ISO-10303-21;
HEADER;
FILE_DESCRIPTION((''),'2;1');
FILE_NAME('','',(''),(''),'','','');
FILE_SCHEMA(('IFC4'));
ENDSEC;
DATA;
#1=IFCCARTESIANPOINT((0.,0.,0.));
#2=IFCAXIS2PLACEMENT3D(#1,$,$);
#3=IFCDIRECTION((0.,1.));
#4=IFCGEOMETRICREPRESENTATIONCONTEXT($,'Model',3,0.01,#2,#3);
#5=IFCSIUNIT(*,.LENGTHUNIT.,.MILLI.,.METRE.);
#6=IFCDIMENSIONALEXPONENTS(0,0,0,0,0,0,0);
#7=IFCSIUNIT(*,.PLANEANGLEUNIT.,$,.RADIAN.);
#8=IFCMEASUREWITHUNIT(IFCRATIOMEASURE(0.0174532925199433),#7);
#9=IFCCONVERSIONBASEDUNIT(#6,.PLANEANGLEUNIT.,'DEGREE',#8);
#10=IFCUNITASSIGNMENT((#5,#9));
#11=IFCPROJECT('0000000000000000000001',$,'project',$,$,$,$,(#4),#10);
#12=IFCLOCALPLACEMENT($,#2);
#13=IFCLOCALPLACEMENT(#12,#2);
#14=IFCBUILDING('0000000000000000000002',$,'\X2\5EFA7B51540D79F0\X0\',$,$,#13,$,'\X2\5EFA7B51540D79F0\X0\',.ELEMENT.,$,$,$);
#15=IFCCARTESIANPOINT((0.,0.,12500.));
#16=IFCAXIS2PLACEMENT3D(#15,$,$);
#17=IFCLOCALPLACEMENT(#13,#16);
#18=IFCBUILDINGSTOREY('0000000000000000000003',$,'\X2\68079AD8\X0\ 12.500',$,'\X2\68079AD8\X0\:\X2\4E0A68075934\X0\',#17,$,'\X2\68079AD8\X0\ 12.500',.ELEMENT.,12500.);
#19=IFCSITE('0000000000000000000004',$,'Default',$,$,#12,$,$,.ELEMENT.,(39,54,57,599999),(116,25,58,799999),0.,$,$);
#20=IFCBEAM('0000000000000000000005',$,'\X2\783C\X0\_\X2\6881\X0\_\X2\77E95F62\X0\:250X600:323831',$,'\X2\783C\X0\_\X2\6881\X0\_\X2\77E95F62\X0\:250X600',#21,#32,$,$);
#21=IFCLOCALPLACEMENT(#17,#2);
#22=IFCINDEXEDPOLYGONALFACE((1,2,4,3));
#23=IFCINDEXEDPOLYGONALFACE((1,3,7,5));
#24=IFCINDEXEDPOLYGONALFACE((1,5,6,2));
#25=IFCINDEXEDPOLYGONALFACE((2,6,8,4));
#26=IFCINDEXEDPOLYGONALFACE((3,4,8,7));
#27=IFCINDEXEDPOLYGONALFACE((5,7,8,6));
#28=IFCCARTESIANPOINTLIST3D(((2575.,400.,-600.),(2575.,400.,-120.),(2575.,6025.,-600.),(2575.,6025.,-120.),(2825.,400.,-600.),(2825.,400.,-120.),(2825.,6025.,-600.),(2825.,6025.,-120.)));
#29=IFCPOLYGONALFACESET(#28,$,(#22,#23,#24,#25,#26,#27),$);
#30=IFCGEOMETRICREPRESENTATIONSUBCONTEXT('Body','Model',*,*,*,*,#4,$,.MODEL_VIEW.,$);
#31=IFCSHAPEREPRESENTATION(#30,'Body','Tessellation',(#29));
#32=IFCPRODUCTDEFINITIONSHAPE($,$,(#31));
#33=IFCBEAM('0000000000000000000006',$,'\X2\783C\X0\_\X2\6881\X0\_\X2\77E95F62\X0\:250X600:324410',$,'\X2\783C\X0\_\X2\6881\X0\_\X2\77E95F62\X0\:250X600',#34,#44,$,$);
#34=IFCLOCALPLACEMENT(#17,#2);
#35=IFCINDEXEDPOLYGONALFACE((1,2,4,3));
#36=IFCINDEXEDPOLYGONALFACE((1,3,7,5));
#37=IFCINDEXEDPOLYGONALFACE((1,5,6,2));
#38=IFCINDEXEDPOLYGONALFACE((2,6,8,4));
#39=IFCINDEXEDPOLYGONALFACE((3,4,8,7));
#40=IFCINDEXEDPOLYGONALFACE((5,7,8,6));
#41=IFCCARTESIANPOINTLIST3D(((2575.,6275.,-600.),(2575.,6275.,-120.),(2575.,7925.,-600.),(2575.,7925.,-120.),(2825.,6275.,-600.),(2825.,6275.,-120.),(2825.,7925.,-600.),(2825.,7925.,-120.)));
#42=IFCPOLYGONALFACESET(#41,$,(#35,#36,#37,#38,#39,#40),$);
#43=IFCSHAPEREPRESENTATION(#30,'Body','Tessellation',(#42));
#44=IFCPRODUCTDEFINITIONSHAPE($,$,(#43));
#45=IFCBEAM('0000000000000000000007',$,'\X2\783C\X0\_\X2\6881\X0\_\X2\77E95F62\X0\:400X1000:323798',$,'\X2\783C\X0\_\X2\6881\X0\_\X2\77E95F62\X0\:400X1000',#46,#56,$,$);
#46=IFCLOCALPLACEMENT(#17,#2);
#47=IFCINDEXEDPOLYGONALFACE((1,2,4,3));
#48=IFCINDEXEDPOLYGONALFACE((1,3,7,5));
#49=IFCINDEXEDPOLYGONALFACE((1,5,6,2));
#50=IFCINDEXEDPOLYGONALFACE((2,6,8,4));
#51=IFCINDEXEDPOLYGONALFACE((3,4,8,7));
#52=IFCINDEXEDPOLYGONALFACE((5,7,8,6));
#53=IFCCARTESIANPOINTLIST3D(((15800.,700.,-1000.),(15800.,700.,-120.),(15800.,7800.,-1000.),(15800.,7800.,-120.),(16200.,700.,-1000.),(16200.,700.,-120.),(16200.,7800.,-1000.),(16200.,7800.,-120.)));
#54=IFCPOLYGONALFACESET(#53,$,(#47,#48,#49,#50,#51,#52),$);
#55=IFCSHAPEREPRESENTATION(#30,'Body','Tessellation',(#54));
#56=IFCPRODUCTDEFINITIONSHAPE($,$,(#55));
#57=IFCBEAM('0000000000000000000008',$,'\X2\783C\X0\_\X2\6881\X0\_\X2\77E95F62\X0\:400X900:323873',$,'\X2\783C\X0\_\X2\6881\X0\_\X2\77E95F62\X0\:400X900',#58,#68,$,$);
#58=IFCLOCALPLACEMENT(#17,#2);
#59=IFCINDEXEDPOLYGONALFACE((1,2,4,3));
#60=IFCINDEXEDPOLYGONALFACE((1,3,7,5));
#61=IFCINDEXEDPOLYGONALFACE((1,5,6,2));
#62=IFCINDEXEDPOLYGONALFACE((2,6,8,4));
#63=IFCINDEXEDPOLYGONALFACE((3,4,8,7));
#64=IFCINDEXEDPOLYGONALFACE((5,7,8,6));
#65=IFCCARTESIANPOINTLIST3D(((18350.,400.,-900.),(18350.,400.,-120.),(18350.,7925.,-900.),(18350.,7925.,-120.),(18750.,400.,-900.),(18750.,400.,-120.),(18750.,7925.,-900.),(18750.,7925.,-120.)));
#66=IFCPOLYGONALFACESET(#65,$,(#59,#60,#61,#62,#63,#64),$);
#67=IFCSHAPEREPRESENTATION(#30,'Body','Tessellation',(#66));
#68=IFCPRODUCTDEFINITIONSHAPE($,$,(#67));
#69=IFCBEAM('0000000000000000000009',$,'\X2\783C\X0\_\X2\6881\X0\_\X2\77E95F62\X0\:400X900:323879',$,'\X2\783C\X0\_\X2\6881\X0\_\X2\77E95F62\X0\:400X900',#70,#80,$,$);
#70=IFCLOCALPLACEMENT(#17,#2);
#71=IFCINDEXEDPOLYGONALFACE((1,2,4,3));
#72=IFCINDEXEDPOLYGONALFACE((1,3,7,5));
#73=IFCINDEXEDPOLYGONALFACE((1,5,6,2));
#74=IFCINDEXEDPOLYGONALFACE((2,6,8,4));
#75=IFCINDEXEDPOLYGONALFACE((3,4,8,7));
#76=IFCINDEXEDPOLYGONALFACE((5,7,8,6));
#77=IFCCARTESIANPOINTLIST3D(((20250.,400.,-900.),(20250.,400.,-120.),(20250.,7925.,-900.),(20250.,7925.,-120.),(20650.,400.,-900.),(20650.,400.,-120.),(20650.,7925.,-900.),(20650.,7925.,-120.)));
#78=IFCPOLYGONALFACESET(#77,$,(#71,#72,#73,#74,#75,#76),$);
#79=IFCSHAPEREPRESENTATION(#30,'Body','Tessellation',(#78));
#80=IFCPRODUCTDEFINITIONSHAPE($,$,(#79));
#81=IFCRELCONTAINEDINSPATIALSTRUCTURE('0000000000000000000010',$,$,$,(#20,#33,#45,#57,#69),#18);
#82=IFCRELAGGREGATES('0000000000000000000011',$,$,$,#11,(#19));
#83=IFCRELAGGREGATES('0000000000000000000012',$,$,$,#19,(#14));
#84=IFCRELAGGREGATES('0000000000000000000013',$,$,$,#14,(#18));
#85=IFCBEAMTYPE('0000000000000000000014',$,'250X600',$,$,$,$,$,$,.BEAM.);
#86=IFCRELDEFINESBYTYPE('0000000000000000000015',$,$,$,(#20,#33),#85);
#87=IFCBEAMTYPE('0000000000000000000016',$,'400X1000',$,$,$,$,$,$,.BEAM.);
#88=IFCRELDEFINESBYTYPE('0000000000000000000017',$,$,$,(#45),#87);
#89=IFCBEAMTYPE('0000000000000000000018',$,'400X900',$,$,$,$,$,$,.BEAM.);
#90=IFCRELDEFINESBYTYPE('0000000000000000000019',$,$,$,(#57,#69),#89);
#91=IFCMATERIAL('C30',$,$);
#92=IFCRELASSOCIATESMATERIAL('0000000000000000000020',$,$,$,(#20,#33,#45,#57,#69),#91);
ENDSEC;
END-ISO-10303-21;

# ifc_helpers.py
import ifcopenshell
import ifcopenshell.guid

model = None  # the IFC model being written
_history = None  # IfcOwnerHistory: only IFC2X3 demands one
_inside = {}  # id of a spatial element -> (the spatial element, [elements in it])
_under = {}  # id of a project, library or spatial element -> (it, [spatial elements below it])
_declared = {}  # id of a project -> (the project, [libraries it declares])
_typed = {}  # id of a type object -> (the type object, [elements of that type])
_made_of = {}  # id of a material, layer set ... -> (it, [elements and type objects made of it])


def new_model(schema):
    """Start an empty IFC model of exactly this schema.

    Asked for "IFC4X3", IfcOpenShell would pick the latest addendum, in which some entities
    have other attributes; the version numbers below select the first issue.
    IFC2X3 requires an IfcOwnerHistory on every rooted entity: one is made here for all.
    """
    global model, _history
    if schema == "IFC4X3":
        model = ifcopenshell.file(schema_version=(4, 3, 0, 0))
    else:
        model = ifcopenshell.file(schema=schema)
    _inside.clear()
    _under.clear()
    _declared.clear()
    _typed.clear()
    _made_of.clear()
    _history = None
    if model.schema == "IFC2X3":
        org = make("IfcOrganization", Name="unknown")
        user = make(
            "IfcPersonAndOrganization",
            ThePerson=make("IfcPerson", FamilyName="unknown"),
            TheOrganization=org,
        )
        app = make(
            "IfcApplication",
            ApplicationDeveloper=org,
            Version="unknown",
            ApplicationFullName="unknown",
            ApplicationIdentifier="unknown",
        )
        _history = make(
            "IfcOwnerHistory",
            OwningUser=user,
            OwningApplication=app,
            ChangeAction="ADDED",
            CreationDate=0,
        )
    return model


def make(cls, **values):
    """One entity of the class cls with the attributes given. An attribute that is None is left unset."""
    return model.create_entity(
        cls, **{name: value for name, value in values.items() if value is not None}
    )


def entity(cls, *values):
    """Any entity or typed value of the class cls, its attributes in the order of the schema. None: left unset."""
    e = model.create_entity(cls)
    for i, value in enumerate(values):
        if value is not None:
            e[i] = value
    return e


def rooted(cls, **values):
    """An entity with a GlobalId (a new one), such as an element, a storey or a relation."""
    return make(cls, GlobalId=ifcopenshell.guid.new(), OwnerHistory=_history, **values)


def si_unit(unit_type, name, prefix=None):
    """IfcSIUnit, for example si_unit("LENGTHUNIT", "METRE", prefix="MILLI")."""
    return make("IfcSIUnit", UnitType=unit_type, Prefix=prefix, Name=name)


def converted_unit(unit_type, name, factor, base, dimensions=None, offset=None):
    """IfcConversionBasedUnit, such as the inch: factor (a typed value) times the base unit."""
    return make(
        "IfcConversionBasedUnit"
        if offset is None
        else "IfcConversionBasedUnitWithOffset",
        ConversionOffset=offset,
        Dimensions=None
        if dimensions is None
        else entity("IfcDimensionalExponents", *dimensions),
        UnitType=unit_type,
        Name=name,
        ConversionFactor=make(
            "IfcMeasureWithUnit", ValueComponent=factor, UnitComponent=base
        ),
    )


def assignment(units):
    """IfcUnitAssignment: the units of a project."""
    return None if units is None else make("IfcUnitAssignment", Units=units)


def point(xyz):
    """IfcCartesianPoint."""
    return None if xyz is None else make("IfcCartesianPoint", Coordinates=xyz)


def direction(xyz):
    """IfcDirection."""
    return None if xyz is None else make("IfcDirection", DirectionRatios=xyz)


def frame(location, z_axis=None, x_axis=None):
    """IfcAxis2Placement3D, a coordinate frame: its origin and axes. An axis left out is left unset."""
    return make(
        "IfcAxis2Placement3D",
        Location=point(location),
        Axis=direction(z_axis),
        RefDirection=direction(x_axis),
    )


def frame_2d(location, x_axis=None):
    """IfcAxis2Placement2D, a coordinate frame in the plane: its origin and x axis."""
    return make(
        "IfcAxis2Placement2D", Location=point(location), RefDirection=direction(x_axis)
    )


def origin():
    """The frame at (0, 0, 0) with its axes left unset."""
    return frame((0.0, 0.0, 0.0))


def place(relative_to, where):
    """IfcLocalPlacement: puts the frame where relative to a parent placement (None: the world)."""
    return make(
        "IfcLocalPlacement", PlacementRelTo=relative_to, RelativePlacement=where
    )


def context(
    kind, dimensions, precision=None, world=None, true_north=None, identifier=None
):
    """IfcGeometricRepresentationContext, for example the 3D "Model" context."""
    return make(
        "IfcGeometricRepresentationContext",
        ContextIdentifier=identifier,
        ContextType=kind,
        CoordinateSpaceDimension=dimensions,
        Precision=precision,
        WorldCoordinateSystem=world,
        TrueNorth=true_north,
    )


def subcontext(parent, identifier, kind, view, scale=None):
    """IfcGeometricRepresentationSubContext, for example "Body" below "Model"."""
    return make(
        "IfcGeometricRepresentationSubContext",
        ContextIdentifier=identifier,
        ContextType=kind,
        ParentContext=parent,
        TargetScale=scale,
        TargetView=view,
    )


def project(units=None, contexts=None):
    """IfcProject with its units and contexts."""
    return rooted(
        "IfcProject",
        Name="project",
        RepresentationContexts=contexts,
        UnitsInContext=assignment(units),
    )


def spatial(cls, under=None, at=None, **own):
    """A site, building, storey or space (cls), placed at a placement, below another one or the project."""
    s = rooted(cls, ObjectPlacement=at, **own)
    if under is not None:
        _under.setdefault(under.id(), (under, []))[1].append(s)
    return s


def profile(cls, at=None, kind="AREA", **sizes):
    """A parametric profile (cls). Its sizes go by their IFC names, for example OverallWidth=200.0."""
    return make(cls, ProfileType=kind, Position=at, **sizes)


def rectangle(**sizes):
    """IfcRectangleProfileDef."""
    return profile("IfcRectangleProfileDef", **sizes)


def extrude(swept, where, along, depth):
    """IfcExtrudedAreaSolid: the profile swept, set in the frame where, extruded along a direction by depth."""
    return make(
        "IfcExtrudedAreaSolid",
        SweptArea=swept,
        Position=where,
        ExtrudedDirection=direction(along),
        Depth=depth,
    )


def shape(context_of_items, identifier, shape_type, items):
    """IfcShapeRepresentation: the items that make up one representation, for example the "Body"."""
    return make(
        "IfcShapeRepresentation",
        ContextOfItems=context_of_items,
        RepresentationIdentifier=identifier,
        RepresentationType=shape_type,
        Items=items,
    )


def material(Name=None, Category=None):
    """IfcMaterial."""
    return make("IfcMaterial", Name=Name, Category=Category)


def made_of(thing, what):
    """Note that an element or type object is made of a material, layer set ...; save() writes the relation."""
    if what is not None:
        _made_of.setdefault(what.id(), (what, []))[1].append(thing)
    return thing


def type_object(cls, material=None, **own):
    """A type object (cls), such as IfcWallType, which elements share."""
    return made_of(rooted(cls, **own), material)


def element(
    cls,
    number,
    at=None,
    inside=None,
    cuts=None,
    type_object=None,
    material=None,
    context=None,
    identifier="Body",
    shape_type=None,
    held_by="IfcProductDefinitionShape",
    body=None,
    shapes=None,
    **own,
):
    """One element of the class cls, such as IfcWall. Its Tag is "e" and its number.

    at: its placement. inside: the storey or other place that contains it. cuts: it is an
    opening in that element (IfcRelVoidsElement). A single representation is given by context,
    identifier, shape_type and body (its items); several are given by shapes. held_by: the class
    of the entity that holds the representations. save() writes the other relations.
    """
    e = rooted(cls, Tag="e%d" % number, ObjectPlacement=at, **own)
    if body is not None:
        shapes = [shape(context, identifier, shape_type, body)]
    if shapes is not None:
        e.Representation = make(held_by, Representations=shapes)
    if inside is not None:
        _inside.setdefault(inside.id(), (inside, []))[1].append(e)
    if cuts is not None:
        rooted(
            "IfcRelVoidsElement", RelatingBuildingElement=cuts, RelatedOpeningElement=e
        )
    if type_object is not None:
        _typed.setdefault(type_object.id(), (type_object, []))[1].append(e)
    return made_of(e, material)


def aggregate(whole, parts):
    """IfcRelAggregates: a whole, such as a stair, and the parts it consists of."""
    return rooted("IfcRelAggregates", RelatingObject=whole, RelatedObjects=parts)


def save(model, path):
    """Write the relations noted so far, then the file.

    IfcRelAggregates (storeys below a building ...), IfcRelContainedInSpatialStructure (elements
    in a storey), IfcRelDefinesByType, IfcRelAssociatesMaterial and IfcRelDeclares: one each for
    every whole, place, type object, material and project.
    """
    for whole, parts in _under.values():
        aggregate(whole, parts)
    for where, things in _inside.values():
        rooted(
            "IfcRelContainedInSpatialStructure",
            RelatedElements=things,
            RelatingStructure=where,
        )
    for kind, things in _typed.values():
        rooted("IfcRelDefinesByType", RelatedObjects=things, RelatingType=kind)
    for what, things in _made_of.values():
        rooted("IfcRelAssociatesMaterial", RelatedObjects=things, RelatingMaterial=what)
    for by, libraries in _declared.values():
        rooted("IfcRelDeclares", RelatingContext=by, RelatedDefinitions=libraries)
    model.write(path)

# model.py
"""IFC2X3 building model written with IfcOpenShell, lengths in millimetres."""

from ifc_helpers import new_model, entity, si_unit, converted_unit, direction, frame, frame_2d, origin, place, context, subcontext, project, spatial, rectangle, extrude, material, type_object, element, save


model = new_model("IFC2X3")

# Units and contexts
model_context = context("Model", 3, precision=0.01, world=origin(), true_north=direction((0.0, 1.0)))
body_context = subcontext(model_context, "Body", "Model", "MODEL_VIEW")
ifc_project = project(units=[si_unit("LENGTHUNIT", "METRE", prefix="MILLI"), converted_unit("PLANEANGLEUNIT", "DEGREE", entity("IfcRatioMeasure", 0.0174532925199433), si_unit("PLANEANGLEUNIT", "RADIAN"), dimensions=[0, 0, 0, 0, 0, 0, 0])], contexts=[model_context])

# Site, building, storey
site_placement = place(None, origin())
site = spatial("IfcSite", under=ifc_project, at=site_placement, Name="Default", CompositionType="ELEMENT", RefLatitude=(39, 54, 57, 599999), RefLongitude=(116, 25, 58, 799999), RefElevation=0.0)
building_placement = place(site_placement, origin())
building = spatial("IfcBuilding", under=site, at=building_placement, Name="建筑名称", LongName="建筑名称", CompositionType="ELEMENT")
storey_placement = place(building_placement, frame((0.0, 0.0, 12500.0)))
storey = spatial("IfcBuildingStorey", under=building, at=storey_placement, Name="标高 12.500", ObjectType="标高:上标头", LongName="标高 12.500", CompositionType="ELEMENT", Elevation=12500.0)

# Shared definitions
ifc_material = material(Name="C30")

# Beams
beam_type_1 = type_object("IfcBeamType", Name="250X600", PredefinedType="BEAM")
beam_1_placement = place(storey_placement, frame((2700.0, 0.0, 0.0), z_axis=(0.0, 0.0, 1.0), x_axis=(0.0, 1.0, 0.0)))
element("IfcBeam", 1, at=beam_1_placement, inside=storey, type_object=beam_type_1, material=ifc_material, Name="砼_梁_矩形:250X600:323831", ObjectType="砼_梁_矩形:250X600", context=body_context, shape_type="SweptSolid", body=[
    extrude(rectangle(XDim=480.0, YDim=250.0, at=frame_2d((0.0, 0.0), x_axis=(1.0, 0.0))), frame((400.0, 0.0, -360.0), z_axis=(1.0, 0.0, 0.0), x_axis=(0.0, 0.0, -1.0)), (0.0, 0.0, 1.0), 5625.0),
])
beam_2_placement = place(storey_placement, frame((2700.0, 6150.0, 0.0), z_axis=(0.0, 0.0, 1.0), x_axis=(0.0, 1.0, 0.0)))
element("IfcBeam", 2, at=beam_2_placement, inside=storey, type_object=beam_type_1, material=ifc_material, Name="砼_梁_矩形:250X600:324410", ObjectType="砼_梁_矩形:250X600", context=body_context, shape_type="SweptSolid", body=[
    extrude(rectangle(XDim=480.0, YDim=250.0, at=frame_2d((0.0, 0.0), x_axis=(1.0, 0.0))), frame((125.0, 0.0, -360.0), z_axis=(1.0, 0.0, 0.0), x_axis=(0.0, 0.0, -1.0)), (0.0, 0.0, 1.0), 1650.0),
])
beam_type_2 = type_object("IfcBeamType", Name="400X1000", PredefinedType="BEAM")
beam_3_placement = place(storey_placement, frame((16000.0, 200.0, 0.0), z_axis=(0.0, 0.0, 1.0), x_axis=(0.0, 1.0, 0.0)))
element("IfcBeam", 3, at=beam_3_placement, inside=storey, type_object=beam_type_2, material=ifc_material, Name="砼_梁_矩形:400X1000:323798", ObjectType="砼_梁_矩形:400X1000", context=body_context, shape_type="SweptSolid", body=[
    extrude(rectangle(XDim=880.0, YDim=400.0, at=frame_2d((0.0, 0.0), x_axis=(1.0, 0.0))), frame((500.0, 0.0, -560.0), z_axis=(1.0, 0.0, 0.0), x_axis=(0.0, 0.0, -1.0)), (0.0, 0.0, 1.0), 7100.0),
])
beam_type_3 = type_object("IfcBeamType", Name="400X900", PredefinedType="BEAM")
beam_4_placement = place(storey_placement, frame((18550.0, 0.0, 0.0), z_axis=(0.0, 0.0, 1.0), x_axis=(0.0, 1.0, 0.0)))
element("IfcBeam", 4, at=beam_4_placement, inside=storey, type_object=beam_type_3, material=ifc_material, Name="砼_梁_矩形:400X900:323873", ObjectType="砼_梁_矩形:400X900", context=body_context, shape_type="SweptSolid", body=[
    extrude(rectangle(XDim=780.0, YDim=400.0, at=frame_2d((0.0, 0.0), x_axis=(1.0, 0.0))), frame((400.0, 0.0, -510.0), z_axis=(1.0, 0.0, 0.0), x_axis=(0.0, 0.0, -1.0)), (0.0, 0.0, 1.0), 7525.0),
])
beam_5_placement = place(storey_placement, frame((20450.0, 0.0, 0.0), z_axis=(0.0, 0.0, 1.0), x_axis=(0.0, 1.0, 0.0)))
element("IfcBeam", 5, at=beam_5_placement, inside=storey, type_object=beam_type_3, material=ifc_material, Name="砼_梁_矩形:400X900:323879", ObjectType="砼_梁_矩形:400X900", context=body_context, shape_type="SweptSolid", body=[
    extrude(rectangle(XDim=780.0, YDim=400.0, at=frame_2d((0.0, 0.0), x_axis=(1.0, 0.0))), frame((400.0, 0.0, -510.0), z_axis=(1.0, 0.0, 0.0), x_axis=(0.0, 0.0, -1.0)), (0.0, 0.0, 1.0), 7525.0),
])

save(model, "model.ifc")
